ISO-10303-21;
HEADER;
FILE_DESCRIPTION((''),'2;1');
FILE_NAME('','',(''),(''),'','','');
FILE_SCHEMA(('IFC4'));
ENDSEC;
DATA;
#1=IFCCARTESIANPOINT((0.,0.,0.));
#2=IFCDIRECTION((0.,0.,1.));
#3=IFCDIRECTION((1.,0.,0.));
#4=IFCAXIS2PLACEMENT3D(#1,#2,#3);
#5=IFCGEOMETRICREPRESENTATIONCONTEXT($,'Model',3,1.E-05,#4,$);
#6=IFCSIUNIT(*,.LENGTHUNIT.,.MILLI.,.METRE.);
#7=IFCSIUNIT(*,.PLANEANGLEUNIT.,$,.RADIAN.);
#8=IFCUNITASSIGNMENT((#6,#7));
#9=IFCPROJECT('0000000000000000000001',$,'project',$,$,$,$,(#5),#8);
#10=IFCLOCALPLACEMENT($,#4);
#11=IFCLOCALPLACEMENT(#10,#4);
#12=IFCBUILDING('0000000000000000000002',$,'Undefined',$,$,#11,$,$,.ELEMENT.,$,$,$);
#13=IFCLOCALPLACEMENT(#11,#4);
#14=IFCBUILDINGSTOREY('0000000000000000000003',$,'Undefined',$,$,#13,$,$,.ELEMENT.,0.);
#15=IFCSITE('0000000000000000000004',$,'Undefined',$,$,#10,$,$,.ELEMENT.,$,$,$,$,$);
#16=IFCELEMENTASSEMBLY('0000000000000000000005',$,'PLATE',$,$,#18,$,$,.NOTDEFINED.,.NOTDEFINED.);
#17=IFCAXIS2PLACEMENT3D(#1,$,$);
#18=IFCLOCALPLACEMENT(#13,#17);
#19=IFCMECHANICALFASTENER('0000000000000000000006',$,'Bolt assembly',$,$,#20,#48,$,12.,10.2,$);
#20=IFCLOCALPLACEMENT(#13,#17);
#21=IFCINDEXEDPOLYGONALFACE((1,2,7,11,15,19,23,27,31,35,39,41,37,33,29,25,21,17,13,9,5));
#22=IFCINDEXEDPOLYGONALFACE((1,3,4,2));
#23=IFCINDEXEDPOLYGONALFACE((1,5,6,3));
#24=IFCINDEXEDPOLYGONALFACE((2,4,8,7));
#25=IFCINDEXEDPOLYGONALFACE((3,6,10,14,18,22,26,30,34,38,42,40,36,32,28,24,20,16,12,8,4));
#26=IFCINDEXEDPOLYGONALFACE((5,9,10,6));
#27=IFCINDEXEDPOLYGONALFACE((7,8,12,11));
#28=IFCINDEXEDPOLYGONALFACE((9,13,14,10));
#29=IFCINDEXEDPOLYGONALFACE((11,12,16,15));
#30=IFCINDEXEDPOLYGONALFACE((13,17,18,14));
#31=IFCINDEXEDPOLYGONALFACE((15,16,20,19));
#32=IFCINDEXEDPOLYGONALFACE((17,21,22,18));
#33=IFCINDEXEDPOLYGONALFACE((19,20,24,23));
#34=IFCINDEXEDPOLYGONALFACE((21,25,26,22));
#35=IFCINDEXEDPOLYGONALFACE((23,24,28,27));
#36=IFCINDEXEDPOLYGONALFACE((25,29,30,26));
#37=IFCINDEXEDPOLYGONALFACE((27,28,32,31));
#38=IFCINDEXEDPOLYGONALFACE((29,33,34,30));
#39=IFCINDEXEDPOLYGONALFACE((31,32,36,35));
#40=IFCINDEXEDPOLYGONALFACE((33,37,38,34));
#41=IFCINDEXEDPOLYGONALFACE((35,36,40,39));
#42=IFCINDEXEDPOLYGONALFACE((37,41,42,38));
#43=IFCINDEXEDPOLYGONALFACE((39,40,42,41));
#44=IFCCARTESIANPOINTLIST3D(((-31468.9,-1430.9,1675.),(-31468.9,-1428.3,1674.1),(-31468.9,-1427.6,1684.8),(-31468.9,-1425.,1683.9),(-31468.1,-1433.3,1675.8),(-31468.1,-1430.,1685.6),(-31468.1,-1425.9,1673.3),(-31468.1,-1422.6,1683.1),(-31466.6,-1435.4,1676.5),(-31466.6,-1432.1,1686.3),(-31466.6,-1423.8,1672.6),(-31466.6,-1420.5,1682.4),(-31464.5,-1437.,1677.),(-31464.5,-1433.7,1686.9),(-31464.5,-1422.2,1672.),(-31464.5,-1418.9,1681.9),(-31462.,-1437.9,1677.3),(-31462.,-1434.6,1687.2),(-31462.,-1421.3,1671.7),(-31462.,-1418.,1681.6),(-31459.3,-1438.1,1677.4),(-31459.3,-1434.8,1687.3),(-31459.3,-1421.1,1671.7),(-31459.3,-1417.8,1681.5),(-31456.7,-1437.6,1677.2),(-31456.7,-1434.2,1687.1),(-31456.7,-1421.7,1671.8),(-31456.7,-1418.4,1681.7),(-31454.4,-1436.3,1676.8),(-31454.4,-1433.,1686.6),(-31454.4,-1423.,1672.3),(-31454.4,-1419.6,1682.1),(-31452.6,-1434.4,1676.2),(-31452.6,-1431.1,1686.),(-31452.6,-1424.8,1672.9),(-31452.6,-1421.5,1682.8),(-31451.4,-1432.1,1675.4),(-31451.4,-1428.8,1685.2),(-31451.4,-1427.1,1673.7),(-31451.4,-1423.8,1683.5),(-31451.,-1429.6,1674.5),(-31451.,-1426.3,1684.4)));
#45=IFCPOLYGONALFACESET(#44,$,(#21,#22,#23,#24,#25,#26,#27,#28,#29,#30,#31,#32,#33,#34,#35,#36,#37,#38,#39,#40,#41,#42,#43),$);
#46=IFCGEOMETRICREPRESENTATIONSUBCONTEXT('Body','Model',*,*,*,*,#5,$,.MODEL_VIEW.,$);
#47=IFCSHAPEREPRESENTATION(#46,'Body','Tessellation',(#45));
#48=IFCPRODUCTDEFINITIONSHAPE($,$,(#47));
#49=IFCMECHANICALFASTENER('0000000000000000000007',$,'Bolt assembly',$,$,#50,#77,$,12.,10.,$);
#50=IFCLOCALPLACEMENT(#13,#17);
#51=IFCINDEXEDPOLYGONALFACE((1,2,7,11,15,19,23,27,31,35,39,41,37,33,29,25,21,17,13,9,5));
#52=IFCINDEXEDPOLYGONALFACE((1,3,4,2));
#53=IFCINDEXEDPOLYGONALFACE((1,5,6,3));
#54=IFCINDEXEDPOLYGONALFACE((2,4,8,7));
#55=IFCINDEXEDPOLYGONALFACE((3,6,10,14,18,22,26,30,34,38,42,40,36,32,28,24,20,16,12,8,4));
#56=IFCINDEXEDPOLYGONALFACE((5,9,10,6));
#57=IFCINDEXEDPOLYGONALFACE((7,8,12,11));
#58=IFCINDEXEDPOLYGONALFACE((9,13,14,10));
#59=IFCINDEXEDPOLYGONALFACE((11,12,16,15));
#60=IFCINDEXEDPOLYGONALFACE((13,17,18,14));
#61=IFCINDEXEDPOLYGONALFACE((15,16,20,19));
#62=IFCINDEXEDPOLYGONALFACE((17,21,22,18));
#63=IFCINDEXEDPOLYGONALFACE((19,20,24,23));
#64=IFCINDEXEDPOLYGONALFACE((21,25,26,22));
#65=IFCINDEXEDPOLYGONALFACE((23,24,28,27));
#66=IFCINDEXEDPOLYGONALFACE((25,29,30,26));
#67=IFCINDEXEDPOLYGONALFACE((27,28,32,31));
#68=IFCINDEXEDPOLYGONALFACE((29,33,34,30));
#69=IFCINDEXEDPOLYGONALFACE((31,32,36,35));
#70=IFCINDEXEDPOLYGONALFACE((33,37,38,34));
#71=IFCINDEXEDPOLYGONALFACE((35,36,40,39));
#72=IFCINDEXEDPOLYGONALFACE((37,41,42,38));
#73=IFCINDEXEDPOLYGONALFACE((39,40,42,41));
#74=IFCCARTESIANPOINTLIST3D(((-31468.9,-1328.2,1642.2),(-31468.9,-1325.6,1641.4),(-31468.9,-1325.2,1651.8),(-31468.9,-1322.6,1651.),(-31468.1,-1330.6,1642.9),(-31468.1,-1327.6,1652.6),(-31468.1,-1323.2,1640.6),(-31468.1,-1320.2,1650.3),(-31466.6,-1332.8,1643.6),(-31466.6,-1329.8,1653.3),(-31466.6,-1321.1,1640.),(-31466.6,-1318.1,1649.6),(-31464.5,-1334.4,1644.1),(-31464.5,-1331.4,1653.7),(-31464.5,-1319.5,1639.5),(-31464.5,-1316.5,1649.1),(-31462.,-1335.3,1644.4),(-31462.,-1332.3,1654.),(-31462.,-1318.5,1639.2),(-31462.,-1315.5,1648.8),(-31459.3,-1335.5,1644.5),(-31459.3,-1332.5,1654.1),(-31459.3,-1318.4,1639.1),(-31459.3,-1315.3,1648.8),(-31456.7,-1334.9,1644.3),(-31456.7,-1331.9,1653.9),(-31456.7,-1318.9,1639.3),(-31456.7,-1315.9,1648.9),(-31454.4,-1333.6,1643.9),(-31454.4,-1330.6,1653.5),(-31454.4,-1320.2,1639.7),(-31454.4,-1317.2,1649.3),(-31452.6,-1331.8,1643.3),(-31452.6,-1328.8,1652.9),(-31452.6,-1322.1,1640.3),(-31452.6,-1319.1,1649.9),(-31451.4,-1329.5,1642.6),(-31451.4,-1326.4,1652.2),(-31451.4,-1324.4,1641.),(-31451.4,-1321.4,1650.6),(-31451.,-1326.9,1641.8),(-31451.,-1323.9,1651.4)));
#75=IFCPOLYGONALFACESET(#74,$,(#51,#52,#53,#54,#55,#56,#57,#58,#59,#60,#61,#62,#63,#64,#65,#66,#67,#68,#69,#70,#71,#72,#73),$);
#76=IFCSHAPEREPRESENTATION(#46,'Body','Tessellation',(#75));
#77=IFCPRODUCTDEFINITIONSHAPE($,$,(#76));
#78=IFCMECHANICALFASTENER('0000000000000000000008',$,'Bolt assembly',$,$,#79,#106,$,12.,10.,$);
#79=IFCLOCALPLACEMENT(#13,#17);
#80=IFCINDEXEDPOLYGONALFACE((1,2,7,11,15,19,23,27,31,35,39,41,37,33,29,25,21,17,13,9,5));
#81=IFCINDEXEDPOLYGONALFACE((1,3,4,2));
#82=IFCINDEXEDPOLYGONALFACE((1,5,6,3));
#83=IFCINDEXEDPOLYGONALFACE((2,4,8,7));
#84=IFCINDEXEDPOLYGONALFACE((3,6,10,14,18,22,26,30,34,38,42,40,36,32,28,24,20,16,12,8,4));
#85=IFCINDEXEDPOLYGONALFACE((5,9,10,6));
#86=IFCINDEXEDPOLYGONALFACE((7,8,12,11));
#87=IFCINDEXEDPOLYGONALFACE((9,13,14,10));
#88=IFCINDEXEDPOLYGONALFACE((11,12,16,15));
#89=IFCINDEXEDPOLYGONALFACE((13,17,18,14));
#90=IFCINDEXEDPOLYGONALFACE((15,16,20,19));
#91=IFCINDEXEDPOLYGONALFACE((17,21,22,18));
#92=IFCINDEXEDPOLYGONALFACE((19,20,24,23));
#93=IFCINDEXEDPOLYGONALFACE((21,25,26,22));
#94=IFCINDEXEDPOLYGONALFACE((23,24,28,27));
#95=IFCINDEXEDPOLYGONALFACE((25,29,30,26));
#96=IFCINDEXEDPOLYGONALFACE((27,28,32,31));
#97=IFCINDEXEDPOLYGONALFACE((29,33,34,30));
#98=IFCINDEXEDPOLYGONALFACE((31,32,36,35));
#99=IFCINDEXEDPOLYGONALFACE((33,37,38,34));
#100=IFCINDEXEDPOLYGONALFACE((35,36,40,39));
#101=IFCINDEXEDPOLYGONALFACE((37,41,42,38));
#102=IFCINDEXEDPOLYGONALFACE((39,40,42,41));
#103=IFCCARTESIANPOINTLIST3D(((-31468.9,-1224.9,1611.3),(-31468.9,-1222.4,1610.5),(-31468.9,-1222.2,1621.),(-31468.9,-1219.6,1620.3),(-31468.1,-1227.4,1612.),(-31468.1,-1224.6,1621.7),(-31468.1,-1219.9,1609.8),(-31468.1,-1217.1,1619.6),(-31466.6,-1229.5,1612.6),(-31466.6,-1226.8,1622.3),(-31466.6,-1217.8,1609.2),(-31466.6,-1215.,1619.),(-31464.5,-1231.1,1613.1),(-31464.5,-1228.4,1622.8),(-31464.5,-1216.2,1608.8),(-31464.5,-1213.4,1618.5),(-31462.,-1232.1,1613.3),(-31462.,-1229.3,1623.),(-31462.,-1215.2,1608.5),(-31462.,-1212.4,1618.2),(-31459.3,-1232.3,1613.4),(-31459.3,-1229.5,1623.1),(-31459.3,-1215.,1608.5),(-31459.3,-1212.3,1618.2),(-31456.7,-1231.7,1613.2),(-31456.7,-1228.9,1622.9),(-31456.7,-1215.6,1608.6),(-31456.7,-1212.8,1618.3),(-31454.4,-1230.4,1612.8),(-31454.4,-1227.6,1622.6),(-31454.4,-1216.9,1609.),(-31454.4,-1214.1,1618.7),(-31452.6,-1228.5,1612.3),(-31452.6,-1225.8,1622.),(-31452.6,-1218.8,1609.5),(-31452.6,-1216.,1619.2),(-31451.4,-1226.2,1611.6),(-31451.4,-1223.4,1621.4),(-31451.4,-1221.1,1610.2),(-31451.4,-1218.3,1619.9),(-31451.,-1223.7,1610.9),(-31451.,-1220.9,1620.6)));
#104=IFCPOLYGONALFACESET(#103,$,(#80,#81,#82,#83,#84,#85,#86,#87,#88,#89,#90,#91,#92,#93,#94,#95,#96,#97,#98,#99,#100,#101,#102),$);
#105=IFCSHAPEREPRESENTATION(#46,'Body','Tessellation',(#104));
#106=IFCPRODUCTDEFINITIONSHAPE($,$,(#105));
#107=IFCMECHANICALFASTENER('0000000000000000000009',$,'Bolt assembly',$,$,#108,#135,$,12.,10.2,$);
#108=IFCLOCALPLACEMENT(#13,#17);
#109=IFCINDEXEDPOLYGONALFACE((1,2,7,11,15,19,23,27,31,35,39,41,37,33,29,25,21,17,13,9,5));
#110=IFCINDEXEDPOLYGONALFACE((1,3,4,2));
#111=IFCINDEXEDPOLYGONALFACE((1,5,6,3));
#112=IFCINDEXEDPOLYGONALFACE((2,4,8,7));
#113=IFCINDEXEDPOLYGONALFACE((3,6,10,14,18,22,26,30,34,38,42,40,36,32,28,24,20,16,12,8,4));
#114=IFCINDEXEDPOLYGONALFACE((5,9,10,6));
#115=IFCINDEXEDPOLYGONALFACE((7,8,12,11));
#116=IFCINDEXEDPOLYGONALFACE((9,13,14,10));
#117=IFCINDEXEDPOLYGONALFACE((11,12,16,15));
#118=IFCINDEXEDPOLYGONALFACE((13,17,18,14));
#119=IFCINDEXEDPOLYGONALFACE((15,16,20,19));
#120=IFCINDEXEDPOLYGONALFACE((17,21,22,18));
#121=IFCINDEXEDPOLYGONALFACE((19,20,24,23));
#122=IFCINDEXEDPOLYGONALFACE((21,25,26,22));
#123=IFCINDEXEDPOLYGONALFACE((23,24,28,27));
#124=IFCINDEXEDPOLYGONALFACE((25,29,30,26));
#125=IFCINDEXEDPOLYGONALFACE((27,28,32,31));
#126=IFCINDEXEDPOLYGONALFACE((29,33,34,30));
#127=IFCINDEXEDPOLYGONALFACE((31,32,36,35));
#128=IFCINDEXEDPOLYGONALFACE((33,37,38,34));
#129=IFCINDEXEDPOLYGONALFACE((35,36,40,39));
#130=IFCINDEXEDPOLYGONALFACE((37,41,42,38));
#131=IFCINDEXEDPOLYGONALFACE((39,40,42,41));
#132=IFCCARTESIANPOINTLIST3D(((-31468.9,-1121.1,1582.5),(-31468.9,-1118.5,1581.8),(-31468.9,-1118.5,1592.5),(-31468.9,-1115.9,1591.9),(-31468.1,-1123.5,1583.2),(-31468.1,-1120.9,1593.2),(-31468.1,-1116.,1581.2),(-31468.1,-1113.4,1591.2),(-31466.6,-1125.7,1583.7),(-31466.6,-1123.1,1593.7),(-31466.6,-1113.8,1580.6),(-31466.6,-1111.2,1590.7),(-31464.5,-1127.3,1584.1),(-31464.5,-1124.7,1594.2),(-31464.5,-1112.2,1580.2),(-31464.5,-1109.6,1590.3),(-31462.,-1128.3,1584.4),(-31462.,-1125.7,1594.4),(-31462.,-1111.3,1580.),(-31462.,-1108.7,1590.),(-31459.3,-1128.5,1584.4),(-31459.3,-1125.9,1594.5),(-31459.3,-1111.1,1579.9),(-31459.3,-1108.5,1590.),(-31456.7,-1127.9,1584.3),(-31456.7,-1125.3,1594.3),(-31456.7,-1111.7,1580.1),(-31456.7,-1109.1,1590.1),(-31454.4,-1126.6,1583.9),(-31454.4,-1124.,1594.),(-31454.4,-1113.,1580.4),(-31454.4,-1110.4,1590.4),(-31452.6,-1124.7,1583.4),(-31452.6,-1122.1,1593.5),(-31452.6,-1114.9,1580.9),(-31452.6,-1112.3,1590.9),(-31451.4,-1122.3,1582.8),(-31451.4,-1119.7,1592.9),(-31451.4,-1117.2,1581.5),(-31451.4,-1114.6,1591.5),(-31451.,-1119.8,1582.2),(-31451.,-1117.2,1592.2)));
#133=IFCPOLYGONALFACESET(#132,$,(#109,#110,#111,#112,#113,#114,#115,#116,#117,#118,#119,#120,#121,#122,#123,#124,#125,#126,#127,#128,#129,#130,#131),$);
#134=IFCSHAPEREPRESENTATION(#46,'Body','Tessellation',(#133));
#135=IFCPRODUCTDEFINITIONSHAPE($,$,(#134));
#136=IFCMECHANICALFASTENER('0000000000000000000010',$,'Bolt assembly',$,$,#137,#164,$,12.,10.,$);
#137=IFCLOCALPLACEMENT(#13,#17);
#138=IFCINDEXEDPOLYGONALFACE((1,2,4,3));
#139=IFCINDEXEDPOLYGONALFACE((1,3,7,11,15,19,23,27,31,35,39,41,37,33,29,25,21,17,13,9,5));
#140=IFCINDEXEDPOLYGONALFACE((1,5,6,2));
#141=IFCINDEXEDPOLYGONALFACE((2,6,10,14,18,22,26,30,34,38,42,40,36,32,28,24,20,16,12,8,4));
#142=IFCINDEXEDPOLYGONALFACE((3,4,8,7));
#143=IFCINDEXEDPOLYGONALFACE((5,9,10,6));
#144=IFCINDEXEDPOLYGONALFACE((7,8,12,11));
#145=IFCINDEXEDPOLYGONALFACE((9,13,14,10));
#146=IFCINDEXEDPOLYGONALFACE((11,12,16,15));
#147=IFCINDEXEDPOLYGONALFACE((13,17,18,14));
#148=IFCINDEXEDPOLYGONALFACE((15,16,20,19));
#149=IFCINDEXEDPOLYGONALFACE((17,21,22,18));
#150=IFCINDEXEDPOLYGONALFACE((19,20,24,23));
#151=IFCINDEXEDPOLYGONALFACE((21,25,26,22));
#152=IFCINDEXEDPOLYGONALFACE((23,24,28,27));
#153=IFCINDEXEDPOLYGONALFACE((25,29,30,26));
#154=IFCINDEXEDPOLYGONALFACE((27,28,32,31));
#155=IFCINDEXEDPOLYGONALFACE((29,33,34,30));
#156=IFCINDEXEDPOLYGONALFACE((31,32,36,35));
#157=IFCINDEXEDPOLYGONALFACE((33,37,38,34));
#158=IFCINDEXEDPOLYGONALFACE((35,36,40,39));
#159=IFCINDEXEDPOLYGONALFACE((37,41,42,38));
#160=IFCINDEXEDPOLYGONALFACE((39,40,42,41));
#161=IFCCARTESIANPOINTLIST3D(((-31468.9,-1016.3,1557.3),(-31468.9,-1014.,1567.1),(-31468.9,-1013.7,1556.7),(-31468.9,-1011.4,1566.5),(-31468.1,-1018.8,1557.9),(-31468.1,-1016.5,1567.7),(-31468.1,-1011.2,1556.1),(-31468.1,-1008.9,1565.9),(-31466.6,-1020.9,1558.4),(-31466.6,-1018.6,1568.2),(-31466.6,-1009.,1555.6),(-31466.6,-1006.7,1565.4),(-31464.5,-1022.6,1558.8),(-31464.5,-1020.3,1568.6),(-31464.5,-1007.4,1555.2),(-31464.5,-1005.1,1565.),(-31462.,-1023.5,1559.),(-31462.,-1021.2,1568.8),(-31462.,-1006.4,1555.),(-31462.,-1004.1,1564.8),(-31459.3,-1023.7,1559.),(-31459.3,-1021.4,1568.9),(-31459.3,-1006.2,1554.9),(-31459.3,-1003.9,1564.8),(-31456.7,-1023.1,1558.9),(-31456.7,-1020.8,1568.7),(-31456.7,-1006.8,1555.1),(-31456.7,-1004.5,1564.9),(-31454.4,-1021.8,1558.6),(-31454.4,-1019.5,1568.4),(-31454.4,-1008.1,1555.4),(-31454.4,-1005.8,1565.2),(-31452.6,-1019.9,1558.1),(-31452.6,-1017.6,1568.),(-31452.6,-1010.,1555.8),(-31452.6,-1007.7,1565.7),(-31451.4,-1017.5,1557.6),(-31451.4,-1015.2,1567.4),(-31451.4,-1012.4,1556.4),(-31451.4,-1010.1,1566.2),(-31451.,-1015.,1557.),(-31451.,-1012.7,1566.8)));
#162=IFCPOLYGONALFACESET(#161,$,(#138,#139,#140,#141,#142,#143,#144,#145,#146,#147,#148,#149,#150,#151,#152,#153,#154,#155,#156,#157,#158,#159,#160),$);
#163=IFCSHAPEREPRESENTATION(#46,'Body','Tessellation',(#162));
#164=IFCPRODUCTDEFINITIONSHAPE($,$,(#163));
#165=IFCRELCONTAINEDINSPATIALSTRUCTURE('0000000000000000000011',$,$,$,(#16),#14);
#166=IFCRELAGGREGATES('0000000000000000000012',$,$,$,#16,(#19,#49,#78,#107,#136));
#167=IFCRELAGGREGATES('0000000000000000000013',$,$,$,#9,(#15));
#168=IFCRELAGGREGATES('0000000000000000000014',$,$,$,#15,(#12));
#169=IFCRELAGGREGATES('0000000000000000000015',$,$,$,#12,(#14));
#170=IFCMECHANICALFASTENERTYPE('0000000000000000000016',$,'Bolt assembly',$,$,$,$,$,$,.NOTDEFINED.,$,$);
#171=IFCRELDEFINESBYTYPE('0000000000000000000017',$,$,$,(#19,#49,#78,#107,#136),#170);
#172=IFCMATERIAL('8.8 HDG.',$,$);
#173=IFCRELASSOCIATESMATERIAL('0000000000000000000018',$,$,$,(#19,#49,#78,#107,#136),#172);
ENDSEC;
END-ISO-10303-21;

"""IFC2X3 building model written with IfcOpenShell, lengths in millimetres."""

from ifc_helpers import new_model, si_unit, frame, origin_with_axes, origin_2d_with_axis, place, context, subcontext, project, spatial, circle, extrude, source, transform, mapped, material, type_object, element, aggregate, save


model = new_model("IFC2X3")

# Units and contexts
model_context = context("Model", 3, precision=1e-05, world=origin_with_axes())
body_context = subcontext(model_context, "Body", "Model", "MODEL_VIEW")
ifc_project = project(units=[si_unit("LENGTHUNIT", "METRE", prefix="MILLI"), si_unit("PLANEANGLEUNIT", "RADIAN")], contexts=[model_context])

# Site, building, storey
site_placement = place(None, origin_with_axes())
site = spatial("IfcSite", under=ifc_project, at=site_placement, Name="Undefined", CompositionType="ELEMENT")
building_placement = place(site_placement, origin_with_axes())
building = spatial("IfcBuilding", under=site, at=building_placement, Name="Undefined", CompositionType="ELEMENT")
storey_placement = place(building_placement, origin_with_axes())
storey = spatial("IfcBuildingStorey", under=building, at=storey_placement, Name="Undefined", CompositionType="ELEMENT", Elevation=0.0)

# Element assembly, mechanical fasteners
assembly_placement = place(storey_placement, origin_with_axes())
assembly = element("IfcElementAssembly", 1, at=assembly_placement, inside=storey, Name="PLATE", AssemblyPlace="NOTDEFINED", PredefinedType="NOTDEFINED")
ifc_material_1 = material(Name="8.8 HDG.")
mechanical_fastener_type = type_object("IfcMechanicalFastenerType", Name="Bolt assembly")
shared_shape_1 = source(origin_with_axes(), body_context, "Body", "SweptSolid", [
    extrude(circle(Radius=9.0, at=origin_2d_with_axis()), frame((0.0, 0.2, 0.0), z_axis=(0.0, 1.0, 0.0), x_axis=(1.0, 0.0, 0.0)), (0.0, 0.0, 1.0), 10.4),
])
mechanical_fastener_1_placement = place(assembly_placement, frame((-31460.0, -1429.7, 1674.4), z_axis=(0.000001, -0.947253, 0.320486), x_axis=(1.0, 0.000001, -0.000001)))
mechanical_fastener_1 = element("IfcMechanicalFastener", 2, at=mechanical_fastener_1_placement, type_object=mechanical_fastener_type, material=ifc_material_1, Name="Bolt assembly", NominalDiameter=12.0, NominalLength=10.2, context=body_context, shape_type="MappedRepresentation", body=[
    mapped(shared_shape_1, transform((0.0, 0.0, 0.0))),
])
shared_shape_2 = source(origin_with_axes(), body_context, "Body", "SweptSolid", [
    extrude(circle(Radius=9.0, at=origin_2d_with_axis()), frame((0.0, 0.8, 0.0), z_axis=(0.0, 1.0, 0.0), x_axis=(1.0, 0.0, 0.0)), (0.0, 0.0, 1.0), 10.1),
])
mechanical_fastener_2_placement = place(assembly_placement, frame((-31460.0, -1327.2, 1641.0), z_axis=(0.000001, -0.954721, 0.297503), x_axis=(1.0, 0.000001, -0.000001)))
mechanical_fastener_2 = element("IfcMechanicalFastener", 3, at=mechanical_fastener_2_placement, type_object=mechanical_fastener_type, material=ifc_material_1, Name="Bolt assembly", NominalDiameter=12.0, NominalLength=10.0, context=body_context, shape_type="MappedRepresentation", body=[
    mapped(shared_shape_2, transform((0.0, 0.0, 0.0))),
])
shared_shape_3 = source(origin_with_axes(), body_context, "Body", "SweptSolid", [
    extrude(circle(Radius=9.0, at=origin_2d_with_axis()), frame((0.0, 0.7, 0.0), z_axis=(0.0, 1.0, 0.0), x_axis=(1.0, 0.0, 0.0)), (0.0, 0.0, 1.0), 10.1),
])
mechanical_fastener_3_placement = place(assembly_placement, frame((-31460.0, -1223.9, 1610.2), z_axis=(0.000001, -0.961631, 0.274347), x_axis=(1.0, 0.000001, -0.000001)))
mechanical_fastener_3 = element("IfcMechanicalFastener", 4, at=mechanical_fastener_3_placement, type_object=mechanical_fastener_type, material=ifc_material_1, Name="Bolt assembly", NominalDiameter=12.0, NominalLength=10.0, context=body_context, shape_type="MappedRepresentation", body=[
    mapped(shared_shape_3, transform((0.0, 0.0, 0.0))),
])
shared_shape_4 = source(origin_with_axes(), body_context, "Body", "SweptSolid", [
    extrude(circle(Radius=9.0, at=origin_2d_with_axis()), frame((0.0, 0.3, 0.0), z_axis=(0.0, 1.0, 0.0), x_axis=(1.0, 0.0, 0.0)), (0.0, 0.0, 1.0), 10.4),
])
mechanical_fastener_4_placement = place(assembly_placement, frame((-31460.0, -1119.8, 1581.9), z_axis=(0.000001, -0.967979, 0.25103), x_axis=(1.0, 0.000001, -0.000001)))
mechanical_fastener_4 = element("IfcMechanicalFastener", 5, at=mechanical_fastener_4_placement, type_object=mechanical_fastener_type, material=ifc_material_1, Name="Bolt assembly", NominalDiameter=12.0, NominalLength=10.2, context=body_context, shape_type="MappedRepresentation", body=[
    mapped(shared_shape_4, transform((0.0, 0.0, 0.0))),
])
shared_shape_5 = source(origin_with_axes(), body_context, "Body", "SweptSolid", [
    extrude(circle(Radius=9.0, at=origin_2d_with_axis()), frame((0.0, 0.9, 0.0), z_axis=(0.0, 1.0, 0.0), x_axis=(1.0, 0.0, 0.0)), (0.0, 0.0, 1.0), 10.1),
])
mechanical_fastener_5_placement = place(assembly_placement, frame((-31460.0, -1015.2, 1556.1), z_axis=(0.000001, -0.973763, 0.227567), x_axis=(1.0, 0.000001, -0.000001)))
mechanical_fastener_5 = element("IfcMechanicalFastener", 6, at=mechanical_fastener_5_placement, type_object=mechanical_fastener_type, material=ifc_material_1, Name="Bolt assembly", NominalDiameter=12.0, NominalLength=10.0, context=body_context, shape_type="MappedRepresentation", body=[
    mapped(shared_shape_5, transform((0.0, 0.0, 0.0))),
])
aggregate(assembly, [mechanical_fastener_1, mechanical_fastener_2, mechanical_fastener_3, mechanical_fastener_4, mechanical_fastener_5])

save(model, "model.ifc")
